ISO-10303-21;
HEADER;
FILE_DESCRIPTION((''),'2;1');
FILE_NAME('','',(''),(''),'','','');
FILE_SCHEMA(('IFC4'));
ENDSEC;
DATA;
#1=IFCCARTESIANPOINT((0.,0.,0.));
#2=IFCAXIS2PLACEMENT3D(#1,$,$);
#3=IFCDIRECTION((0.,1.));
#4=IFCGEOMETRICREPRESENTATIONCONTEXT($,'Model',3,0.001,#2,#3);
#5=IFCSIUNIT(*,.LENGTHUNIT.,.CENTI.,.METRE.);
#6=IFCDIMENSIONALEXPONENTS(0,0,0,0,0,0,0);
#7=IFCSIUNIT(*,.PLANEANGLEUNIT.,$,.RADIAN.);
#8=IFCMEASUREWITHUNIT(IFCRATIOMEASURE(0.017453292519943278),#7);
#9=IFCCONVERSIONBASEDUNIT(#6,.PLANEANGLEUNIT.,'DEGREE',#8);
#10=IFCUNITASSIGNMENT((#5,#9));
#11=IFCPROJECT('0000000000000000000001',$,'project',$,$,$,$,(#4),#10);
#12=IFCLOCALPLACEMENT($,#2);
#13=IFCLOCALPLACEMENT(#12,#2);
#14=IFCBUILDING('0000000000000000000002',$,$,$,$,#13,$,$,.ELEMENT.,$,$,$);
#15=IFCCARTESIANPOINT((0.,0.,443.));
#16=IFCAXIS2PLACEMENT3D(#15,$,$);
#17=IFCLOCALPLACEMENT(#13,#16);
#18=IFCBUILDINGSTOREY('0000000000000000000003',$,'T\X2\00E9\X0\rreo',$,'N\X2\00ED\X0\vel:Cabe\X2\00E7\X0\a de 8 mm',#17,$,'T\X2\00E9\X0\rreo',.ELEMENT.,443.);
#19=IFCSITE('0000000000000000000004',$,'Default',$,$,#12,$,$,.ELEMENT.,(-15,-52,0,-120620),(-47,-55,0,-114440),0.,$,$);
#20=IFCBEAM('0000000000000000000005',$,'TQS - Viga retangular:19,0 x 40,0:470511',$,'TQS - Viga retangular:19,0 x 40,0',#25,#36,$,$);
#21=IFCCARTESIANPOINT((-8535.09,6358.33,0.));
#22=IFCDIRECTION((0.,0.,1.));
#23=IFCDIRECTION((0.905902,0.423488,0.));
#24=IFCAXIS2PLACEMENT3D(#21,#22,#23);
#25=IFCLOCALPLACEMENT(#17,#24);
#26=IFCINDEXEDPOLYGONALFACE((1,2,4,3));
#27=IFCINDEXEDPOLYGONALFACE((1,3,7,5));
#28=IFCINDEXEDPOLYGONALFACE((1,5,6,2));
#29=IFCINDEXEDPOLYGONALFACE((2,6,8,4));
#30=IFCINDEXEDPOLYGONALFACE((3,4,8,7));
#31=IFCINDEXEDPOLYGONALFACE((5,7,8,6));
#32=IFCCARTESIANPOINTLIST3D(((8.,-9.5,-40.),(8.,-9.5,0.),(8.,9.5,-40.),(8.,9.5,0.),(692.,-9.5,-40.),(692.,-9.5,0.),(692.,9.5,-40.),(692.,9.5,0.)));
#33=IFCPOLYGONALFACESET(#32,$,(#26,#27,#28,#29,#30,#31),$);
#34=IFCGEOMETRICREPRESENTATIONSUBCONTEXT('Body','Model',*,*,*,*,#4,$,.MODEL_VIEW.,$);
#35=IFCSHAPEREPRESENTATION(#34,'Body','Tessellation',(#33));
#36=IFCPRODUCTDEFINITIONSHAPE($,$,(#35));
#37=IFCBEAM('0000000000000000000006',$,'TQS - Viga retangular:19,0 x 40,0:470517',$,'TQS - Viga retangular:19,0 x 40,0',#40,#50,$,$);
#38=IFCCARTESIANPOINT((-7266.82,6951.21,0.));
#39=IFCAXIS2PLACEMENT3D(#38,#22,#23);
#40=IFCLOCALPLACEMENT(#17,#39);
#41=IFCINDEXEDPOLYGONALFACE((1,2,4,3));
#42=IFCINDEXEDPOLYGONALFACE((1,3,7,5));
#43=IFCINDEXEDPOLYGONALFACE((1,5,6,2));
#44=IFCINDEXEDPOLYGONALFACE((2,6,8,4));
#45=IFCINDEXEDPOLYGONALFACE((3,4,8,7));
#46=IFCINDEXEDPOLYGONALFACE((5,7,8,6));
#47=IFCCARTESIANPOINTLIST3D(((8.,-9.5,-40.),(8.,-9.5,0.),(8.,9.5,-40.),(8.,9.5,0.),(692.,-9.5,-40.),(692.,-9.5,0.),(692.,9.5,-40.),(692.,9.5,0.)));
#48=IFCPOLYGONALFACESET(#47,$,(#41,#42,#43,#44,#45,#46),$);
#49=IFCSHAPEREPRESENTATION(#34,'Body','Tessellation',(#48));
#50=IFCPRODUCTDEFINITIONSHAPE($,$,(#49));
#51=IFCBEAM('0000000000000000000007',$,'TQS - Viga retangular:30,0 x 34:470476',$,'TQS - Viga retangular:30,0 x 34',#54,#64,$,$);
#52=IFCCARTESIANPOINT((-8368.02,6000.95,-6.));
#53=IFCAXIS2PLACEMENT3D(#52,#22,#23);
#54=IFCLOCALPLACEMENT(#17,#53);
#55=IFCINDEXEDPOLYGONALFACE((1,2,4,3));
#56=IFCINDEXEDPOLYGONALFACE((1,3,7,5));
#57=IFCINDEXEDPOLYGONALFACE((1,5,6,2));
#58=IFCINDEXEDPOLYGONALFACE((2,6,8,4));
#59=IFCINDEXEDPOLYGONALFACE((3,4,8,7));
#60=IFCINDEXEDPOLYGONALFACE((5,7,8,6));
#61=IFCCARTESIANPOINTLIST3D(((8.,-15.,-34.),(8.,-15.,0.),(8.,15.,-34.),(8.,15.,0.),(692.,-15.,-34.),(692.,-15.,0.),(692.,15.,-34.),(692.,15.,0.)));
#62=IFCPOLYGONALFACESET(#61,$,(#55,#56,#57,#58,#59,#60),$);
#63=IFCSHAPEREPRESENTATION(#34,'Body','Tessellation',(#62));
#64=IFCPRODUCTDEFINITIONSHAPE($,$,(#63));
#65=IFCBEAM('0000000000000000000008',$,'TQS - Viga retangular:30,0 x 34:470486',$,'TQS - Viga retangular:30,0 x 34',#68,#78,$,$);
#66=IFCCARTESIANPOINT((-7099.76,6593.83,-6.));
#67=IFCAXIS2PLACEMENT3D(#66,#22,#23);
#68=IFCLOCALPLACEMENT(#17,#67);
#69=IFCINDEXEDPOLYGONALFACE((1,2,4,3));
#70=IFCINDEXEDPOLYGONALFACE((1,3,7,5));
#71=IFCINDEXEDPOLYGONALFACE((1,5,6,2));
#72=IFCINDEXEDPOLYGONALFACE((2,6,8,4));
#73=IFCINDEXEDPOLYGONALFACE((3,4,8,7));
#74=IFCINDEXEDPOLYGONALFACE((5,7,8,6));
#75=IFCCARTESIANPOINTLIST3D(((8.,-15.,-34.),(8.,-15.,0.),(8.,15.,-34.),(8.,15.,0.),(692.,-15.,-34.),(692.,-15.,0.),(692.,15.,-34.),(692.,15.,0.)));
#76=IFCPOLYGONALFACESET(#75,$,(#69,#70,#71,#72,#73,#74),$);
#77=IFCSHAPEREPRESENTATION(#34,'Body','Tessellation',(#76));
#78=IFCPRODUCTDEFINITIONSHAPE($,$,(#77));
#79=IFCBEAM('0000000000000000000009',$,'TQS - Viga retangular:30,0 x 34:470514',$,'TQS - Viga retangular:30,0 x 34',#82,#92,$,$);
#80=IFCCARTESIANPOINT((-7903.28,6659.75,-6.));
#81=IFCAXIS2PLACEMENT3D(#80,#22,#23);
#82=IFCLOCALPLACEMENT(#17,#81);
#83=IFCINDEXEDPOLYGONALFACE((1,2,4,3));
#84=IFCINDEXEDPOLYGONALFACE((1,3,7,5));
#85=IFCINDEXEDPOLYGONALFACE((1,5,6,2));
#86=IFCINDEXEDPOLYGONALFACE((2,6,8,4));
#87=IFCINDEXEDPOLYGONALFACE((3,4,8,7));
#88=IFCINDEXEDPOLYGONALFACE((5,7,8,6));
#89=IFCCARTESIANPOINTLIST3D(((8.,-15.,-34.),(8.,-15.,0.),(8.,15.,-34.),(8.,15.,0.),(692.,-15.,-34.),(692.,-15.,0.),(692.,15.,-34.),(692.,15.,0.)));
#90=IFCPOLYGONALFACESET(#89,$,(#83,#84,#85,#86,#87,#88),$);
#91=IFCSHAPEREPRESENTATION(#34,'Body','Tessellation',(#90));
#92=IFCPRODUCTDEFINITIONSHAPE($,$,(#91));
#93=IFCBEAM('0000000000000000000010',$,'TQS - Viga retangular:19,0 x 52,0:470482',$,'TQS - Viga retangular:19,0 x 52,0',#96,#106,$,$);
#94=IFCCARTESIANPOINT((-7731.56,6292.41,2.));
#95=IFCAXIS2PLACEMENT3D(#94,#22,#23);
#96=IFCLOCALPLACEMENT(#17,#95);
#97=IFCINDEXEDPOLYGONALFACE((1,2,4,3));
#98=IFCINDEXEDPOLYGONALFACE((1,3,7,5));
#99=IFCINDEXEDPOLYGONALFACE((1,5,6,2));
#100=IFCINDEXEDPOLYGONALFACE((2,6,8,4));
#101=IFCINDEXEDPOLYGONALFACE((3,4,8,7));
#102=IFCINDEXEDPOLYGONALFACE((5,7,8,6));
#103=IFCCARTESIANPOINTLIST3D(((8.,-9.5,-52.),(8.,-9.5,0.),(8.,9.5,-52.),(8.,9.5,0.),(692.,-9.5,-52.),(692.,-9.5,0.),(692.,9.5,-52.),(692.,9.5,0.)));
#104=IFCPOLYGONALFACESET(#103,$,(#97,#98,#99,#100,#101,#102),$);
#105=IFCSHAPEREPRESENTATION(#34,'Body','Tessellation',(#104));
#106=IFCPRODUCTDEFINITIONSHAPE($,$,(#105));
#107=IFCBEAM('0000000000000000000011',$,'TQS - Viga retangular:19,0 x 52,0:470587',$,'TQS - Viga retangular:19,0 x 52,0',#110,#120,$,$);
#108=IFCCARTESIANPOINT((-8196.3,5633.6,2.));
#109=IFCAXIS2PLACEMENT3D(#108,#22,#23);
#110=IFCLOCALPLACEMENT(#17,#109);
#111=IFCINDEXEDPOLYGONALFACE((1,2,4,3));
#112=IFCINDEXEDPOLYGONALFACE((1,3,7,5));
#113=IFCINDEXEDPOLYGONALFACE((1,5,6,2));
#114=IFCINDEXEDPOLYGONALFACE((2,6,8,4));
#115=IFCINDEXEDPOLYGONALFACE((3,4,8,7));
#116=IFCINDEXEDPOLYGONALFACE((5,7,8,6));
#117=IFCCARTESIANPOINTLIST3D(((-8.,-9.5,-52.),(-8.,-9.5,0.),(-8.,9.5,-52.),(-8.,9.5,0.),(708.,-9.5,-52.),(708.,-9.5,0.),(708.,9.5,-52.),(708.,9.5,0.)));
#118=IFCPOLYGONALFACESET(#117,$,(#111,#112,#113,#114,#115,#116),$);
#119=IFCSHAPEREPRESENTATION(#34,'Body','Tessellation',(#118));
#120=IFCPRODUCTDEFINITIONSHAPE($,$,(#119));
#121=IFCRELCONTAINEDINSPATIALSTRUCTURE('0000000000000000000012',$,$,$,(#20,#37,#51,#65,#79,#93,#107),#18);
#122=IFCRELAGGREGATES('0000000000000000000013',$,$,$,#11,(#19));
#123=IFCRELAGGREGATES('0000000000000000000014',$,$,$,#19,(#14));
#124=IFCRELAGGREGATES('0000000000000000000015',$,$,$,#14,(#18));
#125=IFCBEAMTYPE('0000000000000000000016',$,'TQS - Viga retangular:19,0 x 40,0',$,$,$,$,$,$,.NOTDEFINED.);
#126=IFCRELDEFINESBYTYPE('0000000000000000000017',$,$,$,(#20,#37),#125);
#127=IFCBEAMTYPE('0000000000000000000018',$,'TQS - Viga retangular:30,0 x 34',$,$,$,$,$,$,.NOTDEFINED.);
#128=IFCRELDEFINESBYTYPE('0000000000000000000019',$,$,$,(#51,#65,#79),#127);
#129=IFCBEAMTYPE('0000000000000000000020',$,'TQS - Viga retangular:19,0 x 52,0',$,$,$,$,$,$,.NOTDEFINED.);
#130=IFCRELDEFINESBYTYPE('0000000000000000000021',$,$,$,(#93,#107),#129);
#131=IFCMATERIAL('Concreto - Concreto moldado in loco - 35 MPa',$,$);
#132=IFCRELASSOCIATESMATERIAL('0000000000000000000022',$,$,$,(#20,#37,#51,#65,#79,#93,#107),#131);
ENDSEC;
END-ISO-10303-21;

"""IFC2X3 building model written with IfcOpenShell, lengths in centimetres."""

from ifc_helpers import new_model, entity, si_unit, converted_unit, direction, frame, frame_2d, origin, origin_2d_with_axis, place, context, subcontext, project, spatial, rectangle, extrude, material, type_object, element, save


model = new_model("IFC2X3")

# Units and contexts
model_context = context("Model", 3, precision=0.001, world=origin(), true_north=direction((0.0, 1.0)))
body_context = subcontext(model_context, "Body", "Model", "MODEL_VIEW")
ifc_project = project(units=[si_unit("LENGTHUNIT", "METRE", prefix="CENTI"), converted_unit("PLANEANGLEUNIT", "DEGREE", entity("IfcRatioMeasure", 0.017453292519943278), si_unit("PLANEANGLEUNIT", "RADIAN"), dimensions=[0, 0, 0, 0, 0, 0, 0])], contexts=[model_context])

# Site, building, storey
site_placement = place(None, origin())
site = spatial("IfcSite", under=ifc_project, at=site_placement, Name="Default", CompositionType="ELEMENT", RefLatitude=(-15, -52, 0, -120620), RefLongitude=(-47, -55, 0, -114440), RefElevation=0.0)
building_placement = place(site_placement, origin())
building = spatial("IfcBuilding", under=site, at=building_placement, CompositionType="ELEMENT")
storey_placement = place(building_placement, frame((0.0, 0.0, 443.0)))
storey = spatial("IfcBuildingStorey", under=building, at=storey_placement, Name="Térreo", ObjectType="Nível:Cabeça de 8 mm", LongName="Térreo", CompositionType="ELEMENT", Elevation=443.0)

# Beams
ifc_material_1 = material(Name="Concreto - Concreto moldado in loco - 35 MPa")
beam_type_1 = type_object("IfcBeamType", Name="TQS - Viga retangular:19,0 x 40,0", PredefinedType="NOTDEFINED")
beam_1_placement = place(storey_placement, frame((-8535.09, 6358.33, 0.0), z_axis=(0.0, 0.0, 1.0), x_axis=(0.905902, 0.423488, 0.0)))
element("IfcBeam", 1, at=beam_1_placement, inside=storey, type_object=beam_type_1, material=ifc_material_1, Name="TQS - Viga retangular:19,0 x 40,0:470511", ObjectType="TQS - Viga retangular:19,0 x 40,0", context=body_context, shape_type="SweptSolid", body=[
    extrude(rectangle(XDim=40.0, YDim=19.0, at=frame_2d((0.0, 0.0), x_axis=(1.0, 0.0))), frame((8.0, 0.0, -20.0), z_axis=(1.0, 0.0, 0.0), x_axis=(0.0, 0.0, -1.0)), (0.0, 0.0, 1.0), 684.0),
])
beam_2_placement = place(storey_placement, frame((-7266.82, 6951.21, 0.0), z_axis=(0.0, 0.0, 1.0), x_axis=(0.905902, 0.423488, 0.0)))
element("IfcBeam", 2, at=beam_2_placement, inside=storey, type_object=beam_type_1, material=ifc_material_1, Name="TQS - Viga retangular:19,0 x 40,0:470517", ObjectType="TQS - Viga retangular:19,0 x 40,0", context=body_context, shape_type="SweptSolid", body=[
    extrude(rectangle(XDim=40.0, YDim=19.0, at=origin_2d_with_axis()), frame((8.0, 0.0, -20.0), z_axis=(1.0, 0.0, 0.0), x_axis=(0.0, 0.0, -1.0)), (0.0, 0.0, 1.0), 684.0),
])
beam_type_2 = type_object("IfcBeamType", Name="TQS - Viga retangular:30,0 x 34", PredefinedType="NOTDEFINED")
beam_3_placement = place(storey_placement, frame((-8368.02, 6000.95, -6.0), z_axis=(0.0, 0.0, 1.0), x_axis=(0.905902, 0.423488, 0.0)))
element("IfcBeam", 3, at=beam_3_placement, inside=storey, type_object=beam_type_2, material=ifc_material_1, Name="TQS - Viga retangular:30,0 x 34:470476", ObjectType="TQS - Viga retangular:30,0 x 34", context=body_context, shape_type="SweptSolid", body=[
    extrude(rectangle(XDim=34.0, YDim=30.0, at=frame_2d((0.0, 0.0), x_axis=(1.0, 0.0))), frame((8.0, 0.0, -17.0), z_axis=(1.0, 0.0, 0.0), x_axis=(0.0, 0.0, -1.0)), (0.0, 0.0, 1.0), 684.0),
])
beam_4_placement = place(storey_placement, frame((-7099.76, 6593.83, -6.0), z_axis=(0.0, 0.0, 1.0), x_axis=(0.905902, 0.423488, 0.0)))
element("IfcBeam", 4, at=beam_4_placement, inside=storey, type_object=beam_type_2, material=ifc_material_1, Name="TQS - Viga retangular:30,0 x 34:470486", ObjectType="TQS - Viga retangular:30,0 x 34", context=body_context, shape_type="SweptSolid", body=[
    extrude(rectangle(XDim=34.0, YDim=30.0, at=frame_2d((0.0, 0.0), x_axis=(1.0, 0.0))), frame((8.0, 0.0, -17.0), z_axis=(1.0, 0.0, 0.0), x_axis=(0.0, 0.0, -1.0)), (0.0, 0.0, 1.0), 684.0),
])
beam_5_placement = place(storey_placement, frame((-7903.28, 6659.75, -6.0), z_axis=(0.0, 0.0, 1.0), x_axis=(0.905902, 0.423488, 0.0)))
element("IfcBeam", 5, at=beam_5_placement, inside=storey, type_object=beam_type_2, material=ifc_material_1, Name="TQS - Viga retangular:30,0 x 34:470514", ObjectType="TQS - Viga retangular:30,0 x 34", context=body_context, shape_type="SweptSolid", body=[
    extrude(rectangle(XDim=34.0, YDim=30.0, at=frame_2d((0.0, 0.0), x_axis=(1.0, 0.0))), frame((8.0, 0.0, -17.0), z_axis=(1.0, 0.0, 0.0), x_axis=(0.0, 0.0, -1.0)), (0.0, 0.0, 1.0), 684.0),
])
beam_type_3 = type_object("IfcBeamType", Name="TQS - Viga retangular:19,0 x 52,0", PredefinedType="NOTDEFINED")
beam_6_placement = place(storey_placement, frame((-7731.56, 6292.41, 2.0), z_axis=(0.0, 0.0, 1.0), x_axis=(0.905902, 0.423488, 0.0)))
element("IfcBeam", 6, at=beam_6_placement, inside=storey, type_object=beam_type_3, material=ifc_material_1, Name="TQS - Viga retangular:19,0 x 52,0:470482", ObjectType="TQS - Viga retangular:19,0 x 52,0", context=body_context, shape_type="SweptSolid", body=[
    extrude(rectangle(XDim=52.0, YDim=19.0, at=frame_2d((0.0, 0.0), x_axis=(1.0, 0.0))), frame((8.0, 0.0, -26.0), z_axis=(1.0, 0.0, 0.0), x_axis=(0.0, 0.0, -1.0)), (0.0, 0.0, 1.0), 684.0),
])
beam_7_placement = place(storey_placement, frame((-8196.3, 5633.6, 2.0), z_axis=(0.0, 0.0, 1.0), x_axis=(0.905902, 0.423488, 0.0)))
element("IfcBeam", 7, at=beam_7_placement, inside=storey, type_object=beam_type_3, material=ifc_material_1, Name="TQS - Viga retangular:19,0 x 52,0:470587", ObjectType="TQS - Viga retangular:19,0 x 52,0", context=body_context, shape_type="SweptSolid", body=[
    extrude(rectangle(XDim=52.0, YDim=19.0, at=origin_2d_with_axis()), frame((-8.0, 0.0, -26.0), z_axis=(1.0, 0.0, 0.0), x_axis=(0.0, 0.0, -1.0)), (0.0, 0.0, 1.0), 716.0),
])

save(model, "model.ifc")
